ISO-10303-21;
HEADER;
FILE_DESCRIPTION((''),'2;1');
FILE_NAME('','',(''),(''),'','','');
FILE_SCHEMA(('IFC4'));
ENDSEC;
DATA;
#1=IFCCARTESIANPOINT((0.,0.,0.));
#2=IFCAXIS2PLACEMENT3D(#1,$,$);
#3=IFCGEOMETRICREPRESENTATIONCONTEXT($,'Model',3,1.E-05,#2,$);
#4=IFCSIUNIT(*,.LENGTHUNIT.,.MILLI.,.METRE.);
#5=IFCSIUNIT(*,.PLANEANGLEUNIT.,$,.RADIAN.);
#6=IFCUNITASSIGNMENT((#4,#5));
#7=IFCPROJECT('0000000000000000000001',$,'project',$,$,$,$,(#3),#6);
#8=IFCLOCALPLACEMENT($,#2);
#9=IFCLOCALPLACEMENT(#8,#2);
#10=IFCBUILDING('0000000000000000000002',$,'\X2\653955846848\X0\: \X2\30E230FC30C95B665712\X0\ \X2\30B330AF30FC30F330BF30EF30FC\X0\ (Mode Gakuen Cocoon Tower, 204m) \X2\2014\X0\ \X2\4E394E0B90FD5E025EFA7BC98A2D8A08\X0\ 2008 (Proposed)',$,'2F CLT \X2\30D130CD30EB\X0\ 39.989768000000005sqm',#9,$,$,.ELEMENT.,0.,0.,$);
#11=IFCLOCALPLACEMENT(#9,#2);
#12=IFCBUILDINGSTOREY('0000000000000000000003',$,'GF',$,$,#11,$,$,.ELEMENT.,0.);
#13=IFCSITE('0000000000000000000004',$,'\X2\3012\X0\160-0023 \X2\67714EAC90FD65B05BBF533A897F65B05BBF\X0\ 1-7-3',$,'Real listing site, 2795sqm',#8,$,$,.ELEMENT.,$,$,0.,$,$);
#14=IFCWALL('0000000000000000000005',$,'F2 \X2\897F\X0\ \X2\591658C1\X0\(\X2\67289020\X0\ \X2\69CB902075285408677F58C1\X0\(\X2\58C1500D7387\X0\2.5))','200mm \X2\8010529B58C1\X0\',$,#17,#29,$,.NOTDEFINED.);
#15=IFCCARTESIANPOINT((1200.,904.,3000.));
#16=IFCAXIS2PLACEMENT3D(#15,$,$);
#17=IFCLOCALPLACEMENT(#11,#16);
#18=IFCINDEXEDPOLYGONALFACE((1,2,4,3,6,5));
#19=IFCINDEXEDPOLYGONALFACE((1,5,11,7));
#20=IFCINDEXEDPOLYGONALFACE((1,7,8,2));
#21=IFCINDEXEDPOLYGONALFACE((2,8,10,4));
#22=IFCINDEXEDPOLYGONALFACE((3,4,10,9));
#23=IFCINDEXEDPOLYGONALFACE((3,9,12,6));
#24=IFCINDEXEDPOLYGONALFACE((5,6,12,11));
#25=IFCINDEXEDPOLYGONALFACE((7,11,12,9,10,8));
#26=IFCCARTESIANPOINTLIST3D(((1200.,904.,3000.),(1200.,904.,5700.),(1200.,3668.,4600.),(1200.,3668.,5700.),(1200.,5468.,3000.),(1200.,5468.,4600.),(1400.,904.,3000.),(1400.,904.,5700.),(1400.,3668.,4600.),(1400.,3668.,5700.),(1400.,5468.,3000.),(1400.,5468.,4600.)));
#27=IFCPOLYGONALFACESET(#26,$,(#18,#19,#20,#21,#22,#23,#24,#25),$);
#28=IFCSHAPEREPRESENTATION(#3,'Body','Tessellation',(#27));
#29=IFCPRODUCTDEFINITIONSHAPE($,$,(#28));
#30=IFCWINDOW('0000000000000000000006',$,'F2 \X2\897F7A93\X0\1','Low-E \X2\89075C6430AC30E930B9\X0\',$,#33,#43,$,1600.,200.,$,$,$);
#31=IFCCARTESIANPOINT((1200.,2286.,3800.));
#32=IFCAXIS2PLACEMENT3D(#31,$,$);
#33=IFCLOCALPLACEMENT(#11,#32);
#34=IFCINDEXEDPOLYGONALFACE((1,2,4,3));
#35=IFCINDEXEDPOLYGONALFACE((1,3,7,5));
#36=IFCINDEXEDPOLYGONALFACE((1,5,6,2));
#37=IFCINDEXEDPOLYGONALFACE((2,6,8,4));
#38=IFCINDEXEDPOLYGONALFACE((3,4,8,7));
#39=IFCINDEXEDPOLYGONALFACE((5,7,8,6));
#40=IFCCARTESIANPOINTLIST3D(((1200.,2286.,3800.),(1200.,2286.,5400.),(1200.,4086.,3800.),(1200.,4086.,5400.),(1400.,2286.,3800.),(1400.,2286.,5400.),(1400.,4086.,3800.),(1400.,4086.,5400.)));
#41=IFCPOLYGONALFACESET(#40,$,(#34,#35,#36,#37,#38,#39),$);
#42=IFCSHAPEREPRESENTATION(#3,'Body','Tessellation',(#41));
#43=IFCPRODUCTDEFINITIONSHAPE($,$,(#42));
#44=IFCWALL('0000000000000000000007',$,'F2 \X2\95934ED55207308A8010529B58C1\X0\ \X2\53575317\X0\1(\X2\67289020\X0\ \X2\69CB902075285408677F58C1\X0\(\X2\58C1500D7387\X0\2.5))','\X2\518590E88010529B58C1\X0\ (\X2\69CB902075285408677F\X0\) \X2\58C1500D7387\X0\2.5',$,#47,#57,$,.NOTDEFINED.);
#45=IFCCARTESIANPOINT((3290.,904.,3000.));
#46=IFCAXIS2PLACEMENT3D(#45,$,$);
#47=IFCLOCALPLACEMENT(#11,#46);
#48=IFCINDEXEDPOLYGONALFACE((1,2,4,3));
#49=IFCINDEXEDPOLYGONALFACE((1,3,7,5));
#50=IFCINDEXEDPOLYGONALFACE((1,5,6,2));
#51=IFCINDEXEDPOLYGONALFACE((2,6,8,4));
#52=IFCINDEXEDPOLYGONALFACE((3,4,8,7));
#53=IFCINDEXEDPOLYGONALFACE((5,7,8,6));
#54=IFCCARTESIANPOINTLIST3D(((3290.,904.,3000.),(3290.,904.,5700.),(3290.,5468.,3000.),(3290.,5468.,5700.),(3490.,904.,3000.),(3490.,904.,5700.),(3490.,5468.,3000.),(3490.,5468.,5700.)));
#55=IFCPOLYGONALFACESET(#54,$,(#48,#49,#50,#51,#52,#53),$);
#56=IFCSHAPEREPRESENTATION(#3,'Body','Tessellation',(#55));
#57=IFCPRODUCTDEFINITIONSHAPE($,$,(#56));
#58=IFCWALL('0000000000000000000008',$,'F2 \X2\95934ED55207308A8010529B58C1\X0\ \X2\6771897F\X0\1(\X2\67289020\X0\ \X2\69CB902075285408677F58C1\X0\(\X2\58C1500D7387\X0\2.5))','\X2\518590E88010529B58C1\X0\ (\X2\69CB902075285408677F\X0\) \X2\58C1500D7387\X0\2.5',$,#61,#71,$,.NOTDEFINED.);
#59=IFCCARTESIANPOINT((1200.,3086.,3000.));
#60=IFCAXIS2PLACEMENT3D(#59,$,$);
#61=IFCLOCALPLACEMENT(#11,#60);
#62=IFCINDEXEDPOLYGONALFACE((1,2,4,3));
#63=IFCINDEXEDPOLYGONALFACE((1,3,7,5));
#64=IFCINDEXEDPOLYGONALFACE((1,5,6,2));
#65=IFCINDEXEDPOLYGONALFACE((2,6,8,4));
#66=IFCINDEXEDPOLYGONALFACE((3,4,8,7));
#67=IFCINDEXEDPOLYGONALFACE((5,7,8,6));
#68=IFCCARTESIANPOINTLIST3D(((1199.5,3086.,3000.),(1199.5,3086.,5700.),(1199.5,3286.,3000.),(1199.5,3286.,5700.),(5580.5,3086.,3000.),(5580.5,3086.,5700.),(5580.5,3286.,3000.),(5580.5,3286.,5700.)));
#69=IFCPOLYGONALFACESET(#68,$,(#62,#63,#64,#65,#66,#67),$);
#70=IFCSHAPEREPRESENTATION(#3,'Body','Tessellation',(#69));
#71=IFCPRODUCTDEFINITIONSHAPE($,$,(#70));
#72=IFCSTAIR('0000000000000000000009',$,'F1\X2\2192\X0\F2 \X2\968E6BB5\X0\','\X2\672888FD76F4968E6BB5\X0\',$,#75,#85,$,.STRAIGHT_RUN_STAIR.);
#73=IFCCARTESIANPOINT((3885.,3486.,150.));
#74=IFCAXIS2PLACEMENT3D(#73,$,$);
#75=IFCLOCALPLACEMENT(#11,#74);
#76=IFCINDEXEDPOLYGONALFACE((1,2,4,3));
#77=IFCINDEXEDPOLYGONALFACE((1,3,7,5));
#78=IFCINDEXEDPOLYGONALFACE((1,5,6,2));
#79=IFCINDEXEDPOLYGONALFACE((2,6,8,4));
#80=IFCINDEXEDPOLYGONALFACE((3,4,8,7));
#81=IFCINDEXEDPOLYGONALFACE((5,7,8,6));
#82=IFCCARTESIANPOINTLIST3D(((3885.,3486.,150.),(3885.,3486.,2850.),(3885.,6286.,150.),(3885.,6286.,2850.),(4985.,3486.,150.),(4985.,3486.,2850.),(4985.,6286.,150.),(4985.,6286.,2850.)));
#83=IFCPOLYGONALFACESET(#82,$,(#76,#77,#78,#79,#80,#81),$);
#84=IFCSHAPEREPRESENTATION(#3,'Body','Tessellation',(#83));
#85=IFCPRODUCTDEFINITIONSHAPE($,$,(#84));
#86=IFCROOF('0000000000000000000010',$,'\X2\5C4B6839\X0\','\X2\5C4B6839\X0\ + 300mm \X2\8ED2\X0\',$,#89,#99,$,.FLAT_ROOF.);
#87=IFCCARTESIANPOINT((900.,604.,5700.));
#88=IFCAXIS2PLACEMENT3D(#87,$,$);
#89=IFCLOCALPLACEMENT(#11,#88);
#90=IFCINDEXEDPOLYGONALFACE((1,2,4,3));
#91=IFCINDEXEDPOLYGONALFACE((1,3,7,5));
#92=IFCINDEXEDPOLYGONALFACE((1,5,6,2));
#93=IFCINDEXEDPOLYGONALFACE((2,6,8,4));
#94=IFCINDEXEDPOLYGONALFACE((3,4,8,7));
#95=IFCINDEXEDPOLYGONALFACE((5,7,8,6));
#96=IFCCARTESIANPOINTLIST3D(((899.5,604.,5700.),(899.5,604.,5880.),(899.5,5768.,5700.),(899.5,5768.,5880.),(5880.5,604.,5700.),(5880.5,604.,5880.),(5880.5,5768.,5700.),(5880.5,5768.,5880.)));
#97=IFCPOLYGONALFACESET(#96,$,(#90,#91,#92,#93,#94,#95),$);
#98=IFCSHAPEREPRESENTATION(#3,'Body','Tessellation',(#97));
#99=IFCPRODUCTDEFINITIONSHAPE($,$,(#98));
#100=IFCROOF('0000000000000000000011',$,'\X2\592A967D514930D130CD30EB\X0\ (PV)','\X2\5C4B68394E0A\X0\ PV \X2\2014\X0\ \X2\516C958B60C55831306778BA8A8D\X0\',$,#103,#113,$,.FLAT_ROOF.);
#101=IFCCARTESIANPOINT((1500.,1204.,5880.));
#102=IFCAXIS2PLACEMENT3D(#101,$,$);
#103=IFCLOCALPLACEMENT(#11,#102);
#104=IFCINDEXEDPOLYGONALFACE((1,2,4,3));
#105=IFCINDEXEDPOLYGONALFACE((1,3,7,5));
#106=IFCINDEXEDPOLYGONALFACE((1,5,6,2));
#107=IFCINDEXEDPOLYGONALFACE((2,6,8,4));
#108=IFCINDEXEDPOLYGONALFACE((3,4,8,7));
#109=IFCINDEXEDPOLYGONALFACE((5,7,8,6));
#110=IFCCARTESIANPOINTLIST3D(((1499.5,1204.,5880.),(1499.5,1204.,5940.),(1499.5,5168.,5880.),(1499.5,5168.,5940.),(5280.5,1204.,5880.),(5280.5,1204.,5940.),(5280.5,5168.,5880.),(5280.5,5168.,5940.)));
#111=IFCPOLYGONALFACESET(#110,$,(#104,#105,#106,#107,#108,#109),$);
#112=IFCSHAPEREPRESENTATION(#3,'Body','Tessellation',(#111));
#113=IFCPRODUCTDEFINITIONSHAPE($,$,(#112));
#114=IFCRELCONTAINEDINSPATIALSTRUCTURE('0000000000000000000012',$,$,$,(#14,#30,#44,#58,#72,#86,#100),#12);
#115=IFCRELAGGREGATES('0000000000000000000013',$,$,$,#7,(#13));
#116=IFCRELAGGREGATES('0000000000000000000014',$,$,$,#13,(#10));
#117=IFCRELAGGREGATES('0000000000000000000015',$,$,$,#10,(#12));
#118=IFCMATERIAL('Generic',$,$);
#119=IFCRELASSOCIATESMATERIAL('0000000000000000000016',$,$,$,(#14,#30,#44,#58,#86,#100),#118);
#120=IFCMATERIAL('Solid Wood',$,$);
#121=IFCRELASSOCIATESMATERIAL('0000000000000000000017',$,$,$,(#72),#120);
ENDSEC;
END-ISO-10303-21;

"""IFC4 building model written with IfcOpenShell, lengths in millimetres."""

from ifc_helpers import new_model, si_unit, frame, frame_2d, origin, place, context, project, spatial, rectangle, extrude, material, element, fill, save


model = new_model("IFC4")

# Units and contexts
model_context = context("Model", 3, precision=1e-05, world=origin())
ifc_project = project(units=[si_unit("LENGTHUNIT", "METRE", prefix="MILLI"), si_unit("PLANEANGLEUNIT", "RADIAN")], contexts=[model_context])

# Site, building, storey
site_placement = place(None, origin())
site = spatial("IfcSite", under=ifc_project, at=site_placement, Name="〒160-0023 東京都新宿区西新宿 1-7-3", ObjectType="Real listing site, 2795sqm", CompositionType="ELEMENT", RefElevation=0.0)
building_placement = place(site_placement, origin())
building = spatial("IfcBuilding", under=site, at=building_placement, Name="改善案: モード学園 コクーンタワー (Mode Gakuen Cocoon Tower, 204m) — 丹下都市建築設計 2008 (Proposed)", ObjectType="2F CLT パネル 39.989768000000005sqm", CompositionType="ELEMENT", ElevationOfRefHeight=0.0, ElevationOfTerrain=0.0)
storey_placement = place(building_placement, origin())
storey = spatial("IfcBuildingStorey", under=building, at=storey_placement, Name="GF", CompositionType="ELEMENT", Elevation=0.0)

# Shared definitions
ifc_material_1 = material(Name="Generic")

# Shared definitions
ifc_material_2 = material(Name="Solid Wood")

# Wall, opening, window
wall_1_placement = place(storey_placement, frame((1200.0, 904.0, 3000.0)))
wall_1 = element("IfcWall", 1, at=wall_1_placement, inside=storey, material=ifc_material_1, Name="F2 西 外壁(木造 構造用合板壁(壁倍率2.5))", Description="200mm 耐力壁", PredefinedType="NOTDEFINED", context=model_context, shape_type="SweptSolid", body=[
    extrude(rectangle(XDim=200.0, YDim=4564.0, at=frame_2d((100.0, 2282.0))), frame((1200.0, 904.0, 3000.0)), (0.0, 0.0, 1.0), 2700.0),
])
opening_1_placement = place(storey_placement, frame((1200.0, 2286.0, 3800.0)))
opening_1 = element("IfcOpeningElement", 2, at=opening_1_placement, cuts=wall_1, PredefinedType="NOTDEFINED", context=model_context, shape_type="SweptSolid", body=[
    extrude(rectangle(XDim=200.0, YDim=1800.0, at=frame_2d((100.0, 900.0))), frame((1200.0, 2286.0, 3800.0)), (0.0, 0.0, 1.0), 1600.0),
])
window_1_placement = place(storey_placement, frame((1200.0, 2286.0, 3800.0)))
window_1 = element("IfcWindow", 3, at=window_1_placement, inside=storey, material=ifc_material_1, Name="F2 西窓1", Description="Low-E 複層ガラス", OverallHeight=1600.0, OverallWidth=200.0, context=model_context, shape_type="SweptSolid", body=[
    extrude(rectangle(XDim=200.0, YDim=1800.0, at=frame_2d((100.0, 900.0))), frame((1200.0, 2286.0, 3800.0)), (0.0, 0.0, 1.0), 1600.0),
])
fill(opening_1, window_1)

# Walls
wall_2_placement = place(storey_placement, frame((3290.0, 904.0, 3000.0)))
element("IfcWall", 4, at=wall_2_placement, inside=storey, material=ifc_material_1, Name="F2 間仕切り耐力壁 南北1(木造 構造用合板壁(壁倍率2.5))", Description="内部耐力壁 (構造用合板) 壁倍率2.5", PredefinedType="NOTDEFINED", context=model_context, shape_type="SweptSolid", body=[
    extrude(rectangle(XDim=200.0, YDim=4564.0, at=frame_2d((100.0, 2282.0))), frame((3290.0, 904.0, 3000.0)), (0.0, 0.0, 1.0), 2700.0),
])
wall_3_placement = place(storey_placement, frame((1200.0, 3086.0, 3000.0)))
element("IfcWall", 5, at=wall_3_placement, inside=storey, material=ifc_material_1, Name="F2 間仕切り耐力壁 東西1(木造 構造用合板壁(壁倍率2.5))", Description="内部耐力壁 (構造用合板) 壁倍率2.5", PredefinedType="NOTDEFINED", context=model_context, shape_type="SweptSolid", body=[
    extrude(rectangle(XDim=4381.0, YDim=200.0, at=frame_2d((2190.0, 100.0))), frame((1200.0, 3086.0, 3000.0)), (0.0, 0.0, 1.0), 2700.0),
])

# Stair
stair_placement = place(storey_placement, frame((3885.0, 3486.0, 150.0)))
element("IfcStair", 6, at=stair_placement, inside=storey, material=ifc_material_2, Name="F1→F2 階段", Description="木製直階段", PredefinedType="STRAIGHT_RUN_STAIR", context=model_context, shape_type="SweptSolid", body=[
    extrude(rectangle(XDim=1100.0, YDim=2800.0, at=frame_2d((550.0, 1400.0))), frame((3885.0, 3486.0, 150.0)), (0.0, 0.0, 1.0), 2700.0),
])

# Roofs
roof_1_placement = place(storey_placement, frame((900.0, 604.0, 5700.0)))
element("IfcRoof", 7, at=roof_1_placement, inside=storey, material=ifc_material_1, Name="屋根", Description="屋根 + 300mm 軒", PredefinedType="FLAT_ROOF", context=model_context, shape_type="SweptSolid", body=[
    extrude(rectangle(XDim=4981.0, YDim=5164.0, at=frame_2d((2490.0, 2582.0))), frame((900.0, 604.0, 5700.0)), (0.0, 0.0, 1.0), 180.0),
])
roof_2_placement = place(storey_placement, frame((1500.0, 1204.0, 5880.0)))
element("IfcRoof", 8, at=roof_2_placement, inside=storey, material=ifc_material_1, Name="太陽光パネル (PV)", Description="屋根上 PV — 公開情報で確認", PredefinedType="FLAT_ROOF", context=model_context, shape_type="SweptSolid", body=[
    extrude(rectangle(XDim=3781.0, YDim=3964.0, at=frame_2d((1890.0, 1982.0))), frame((1500.0, 1204.0, 5880.0)), (0.0, 0.0, 1.0), 60.0),
])

save(model, "model.ifc")
